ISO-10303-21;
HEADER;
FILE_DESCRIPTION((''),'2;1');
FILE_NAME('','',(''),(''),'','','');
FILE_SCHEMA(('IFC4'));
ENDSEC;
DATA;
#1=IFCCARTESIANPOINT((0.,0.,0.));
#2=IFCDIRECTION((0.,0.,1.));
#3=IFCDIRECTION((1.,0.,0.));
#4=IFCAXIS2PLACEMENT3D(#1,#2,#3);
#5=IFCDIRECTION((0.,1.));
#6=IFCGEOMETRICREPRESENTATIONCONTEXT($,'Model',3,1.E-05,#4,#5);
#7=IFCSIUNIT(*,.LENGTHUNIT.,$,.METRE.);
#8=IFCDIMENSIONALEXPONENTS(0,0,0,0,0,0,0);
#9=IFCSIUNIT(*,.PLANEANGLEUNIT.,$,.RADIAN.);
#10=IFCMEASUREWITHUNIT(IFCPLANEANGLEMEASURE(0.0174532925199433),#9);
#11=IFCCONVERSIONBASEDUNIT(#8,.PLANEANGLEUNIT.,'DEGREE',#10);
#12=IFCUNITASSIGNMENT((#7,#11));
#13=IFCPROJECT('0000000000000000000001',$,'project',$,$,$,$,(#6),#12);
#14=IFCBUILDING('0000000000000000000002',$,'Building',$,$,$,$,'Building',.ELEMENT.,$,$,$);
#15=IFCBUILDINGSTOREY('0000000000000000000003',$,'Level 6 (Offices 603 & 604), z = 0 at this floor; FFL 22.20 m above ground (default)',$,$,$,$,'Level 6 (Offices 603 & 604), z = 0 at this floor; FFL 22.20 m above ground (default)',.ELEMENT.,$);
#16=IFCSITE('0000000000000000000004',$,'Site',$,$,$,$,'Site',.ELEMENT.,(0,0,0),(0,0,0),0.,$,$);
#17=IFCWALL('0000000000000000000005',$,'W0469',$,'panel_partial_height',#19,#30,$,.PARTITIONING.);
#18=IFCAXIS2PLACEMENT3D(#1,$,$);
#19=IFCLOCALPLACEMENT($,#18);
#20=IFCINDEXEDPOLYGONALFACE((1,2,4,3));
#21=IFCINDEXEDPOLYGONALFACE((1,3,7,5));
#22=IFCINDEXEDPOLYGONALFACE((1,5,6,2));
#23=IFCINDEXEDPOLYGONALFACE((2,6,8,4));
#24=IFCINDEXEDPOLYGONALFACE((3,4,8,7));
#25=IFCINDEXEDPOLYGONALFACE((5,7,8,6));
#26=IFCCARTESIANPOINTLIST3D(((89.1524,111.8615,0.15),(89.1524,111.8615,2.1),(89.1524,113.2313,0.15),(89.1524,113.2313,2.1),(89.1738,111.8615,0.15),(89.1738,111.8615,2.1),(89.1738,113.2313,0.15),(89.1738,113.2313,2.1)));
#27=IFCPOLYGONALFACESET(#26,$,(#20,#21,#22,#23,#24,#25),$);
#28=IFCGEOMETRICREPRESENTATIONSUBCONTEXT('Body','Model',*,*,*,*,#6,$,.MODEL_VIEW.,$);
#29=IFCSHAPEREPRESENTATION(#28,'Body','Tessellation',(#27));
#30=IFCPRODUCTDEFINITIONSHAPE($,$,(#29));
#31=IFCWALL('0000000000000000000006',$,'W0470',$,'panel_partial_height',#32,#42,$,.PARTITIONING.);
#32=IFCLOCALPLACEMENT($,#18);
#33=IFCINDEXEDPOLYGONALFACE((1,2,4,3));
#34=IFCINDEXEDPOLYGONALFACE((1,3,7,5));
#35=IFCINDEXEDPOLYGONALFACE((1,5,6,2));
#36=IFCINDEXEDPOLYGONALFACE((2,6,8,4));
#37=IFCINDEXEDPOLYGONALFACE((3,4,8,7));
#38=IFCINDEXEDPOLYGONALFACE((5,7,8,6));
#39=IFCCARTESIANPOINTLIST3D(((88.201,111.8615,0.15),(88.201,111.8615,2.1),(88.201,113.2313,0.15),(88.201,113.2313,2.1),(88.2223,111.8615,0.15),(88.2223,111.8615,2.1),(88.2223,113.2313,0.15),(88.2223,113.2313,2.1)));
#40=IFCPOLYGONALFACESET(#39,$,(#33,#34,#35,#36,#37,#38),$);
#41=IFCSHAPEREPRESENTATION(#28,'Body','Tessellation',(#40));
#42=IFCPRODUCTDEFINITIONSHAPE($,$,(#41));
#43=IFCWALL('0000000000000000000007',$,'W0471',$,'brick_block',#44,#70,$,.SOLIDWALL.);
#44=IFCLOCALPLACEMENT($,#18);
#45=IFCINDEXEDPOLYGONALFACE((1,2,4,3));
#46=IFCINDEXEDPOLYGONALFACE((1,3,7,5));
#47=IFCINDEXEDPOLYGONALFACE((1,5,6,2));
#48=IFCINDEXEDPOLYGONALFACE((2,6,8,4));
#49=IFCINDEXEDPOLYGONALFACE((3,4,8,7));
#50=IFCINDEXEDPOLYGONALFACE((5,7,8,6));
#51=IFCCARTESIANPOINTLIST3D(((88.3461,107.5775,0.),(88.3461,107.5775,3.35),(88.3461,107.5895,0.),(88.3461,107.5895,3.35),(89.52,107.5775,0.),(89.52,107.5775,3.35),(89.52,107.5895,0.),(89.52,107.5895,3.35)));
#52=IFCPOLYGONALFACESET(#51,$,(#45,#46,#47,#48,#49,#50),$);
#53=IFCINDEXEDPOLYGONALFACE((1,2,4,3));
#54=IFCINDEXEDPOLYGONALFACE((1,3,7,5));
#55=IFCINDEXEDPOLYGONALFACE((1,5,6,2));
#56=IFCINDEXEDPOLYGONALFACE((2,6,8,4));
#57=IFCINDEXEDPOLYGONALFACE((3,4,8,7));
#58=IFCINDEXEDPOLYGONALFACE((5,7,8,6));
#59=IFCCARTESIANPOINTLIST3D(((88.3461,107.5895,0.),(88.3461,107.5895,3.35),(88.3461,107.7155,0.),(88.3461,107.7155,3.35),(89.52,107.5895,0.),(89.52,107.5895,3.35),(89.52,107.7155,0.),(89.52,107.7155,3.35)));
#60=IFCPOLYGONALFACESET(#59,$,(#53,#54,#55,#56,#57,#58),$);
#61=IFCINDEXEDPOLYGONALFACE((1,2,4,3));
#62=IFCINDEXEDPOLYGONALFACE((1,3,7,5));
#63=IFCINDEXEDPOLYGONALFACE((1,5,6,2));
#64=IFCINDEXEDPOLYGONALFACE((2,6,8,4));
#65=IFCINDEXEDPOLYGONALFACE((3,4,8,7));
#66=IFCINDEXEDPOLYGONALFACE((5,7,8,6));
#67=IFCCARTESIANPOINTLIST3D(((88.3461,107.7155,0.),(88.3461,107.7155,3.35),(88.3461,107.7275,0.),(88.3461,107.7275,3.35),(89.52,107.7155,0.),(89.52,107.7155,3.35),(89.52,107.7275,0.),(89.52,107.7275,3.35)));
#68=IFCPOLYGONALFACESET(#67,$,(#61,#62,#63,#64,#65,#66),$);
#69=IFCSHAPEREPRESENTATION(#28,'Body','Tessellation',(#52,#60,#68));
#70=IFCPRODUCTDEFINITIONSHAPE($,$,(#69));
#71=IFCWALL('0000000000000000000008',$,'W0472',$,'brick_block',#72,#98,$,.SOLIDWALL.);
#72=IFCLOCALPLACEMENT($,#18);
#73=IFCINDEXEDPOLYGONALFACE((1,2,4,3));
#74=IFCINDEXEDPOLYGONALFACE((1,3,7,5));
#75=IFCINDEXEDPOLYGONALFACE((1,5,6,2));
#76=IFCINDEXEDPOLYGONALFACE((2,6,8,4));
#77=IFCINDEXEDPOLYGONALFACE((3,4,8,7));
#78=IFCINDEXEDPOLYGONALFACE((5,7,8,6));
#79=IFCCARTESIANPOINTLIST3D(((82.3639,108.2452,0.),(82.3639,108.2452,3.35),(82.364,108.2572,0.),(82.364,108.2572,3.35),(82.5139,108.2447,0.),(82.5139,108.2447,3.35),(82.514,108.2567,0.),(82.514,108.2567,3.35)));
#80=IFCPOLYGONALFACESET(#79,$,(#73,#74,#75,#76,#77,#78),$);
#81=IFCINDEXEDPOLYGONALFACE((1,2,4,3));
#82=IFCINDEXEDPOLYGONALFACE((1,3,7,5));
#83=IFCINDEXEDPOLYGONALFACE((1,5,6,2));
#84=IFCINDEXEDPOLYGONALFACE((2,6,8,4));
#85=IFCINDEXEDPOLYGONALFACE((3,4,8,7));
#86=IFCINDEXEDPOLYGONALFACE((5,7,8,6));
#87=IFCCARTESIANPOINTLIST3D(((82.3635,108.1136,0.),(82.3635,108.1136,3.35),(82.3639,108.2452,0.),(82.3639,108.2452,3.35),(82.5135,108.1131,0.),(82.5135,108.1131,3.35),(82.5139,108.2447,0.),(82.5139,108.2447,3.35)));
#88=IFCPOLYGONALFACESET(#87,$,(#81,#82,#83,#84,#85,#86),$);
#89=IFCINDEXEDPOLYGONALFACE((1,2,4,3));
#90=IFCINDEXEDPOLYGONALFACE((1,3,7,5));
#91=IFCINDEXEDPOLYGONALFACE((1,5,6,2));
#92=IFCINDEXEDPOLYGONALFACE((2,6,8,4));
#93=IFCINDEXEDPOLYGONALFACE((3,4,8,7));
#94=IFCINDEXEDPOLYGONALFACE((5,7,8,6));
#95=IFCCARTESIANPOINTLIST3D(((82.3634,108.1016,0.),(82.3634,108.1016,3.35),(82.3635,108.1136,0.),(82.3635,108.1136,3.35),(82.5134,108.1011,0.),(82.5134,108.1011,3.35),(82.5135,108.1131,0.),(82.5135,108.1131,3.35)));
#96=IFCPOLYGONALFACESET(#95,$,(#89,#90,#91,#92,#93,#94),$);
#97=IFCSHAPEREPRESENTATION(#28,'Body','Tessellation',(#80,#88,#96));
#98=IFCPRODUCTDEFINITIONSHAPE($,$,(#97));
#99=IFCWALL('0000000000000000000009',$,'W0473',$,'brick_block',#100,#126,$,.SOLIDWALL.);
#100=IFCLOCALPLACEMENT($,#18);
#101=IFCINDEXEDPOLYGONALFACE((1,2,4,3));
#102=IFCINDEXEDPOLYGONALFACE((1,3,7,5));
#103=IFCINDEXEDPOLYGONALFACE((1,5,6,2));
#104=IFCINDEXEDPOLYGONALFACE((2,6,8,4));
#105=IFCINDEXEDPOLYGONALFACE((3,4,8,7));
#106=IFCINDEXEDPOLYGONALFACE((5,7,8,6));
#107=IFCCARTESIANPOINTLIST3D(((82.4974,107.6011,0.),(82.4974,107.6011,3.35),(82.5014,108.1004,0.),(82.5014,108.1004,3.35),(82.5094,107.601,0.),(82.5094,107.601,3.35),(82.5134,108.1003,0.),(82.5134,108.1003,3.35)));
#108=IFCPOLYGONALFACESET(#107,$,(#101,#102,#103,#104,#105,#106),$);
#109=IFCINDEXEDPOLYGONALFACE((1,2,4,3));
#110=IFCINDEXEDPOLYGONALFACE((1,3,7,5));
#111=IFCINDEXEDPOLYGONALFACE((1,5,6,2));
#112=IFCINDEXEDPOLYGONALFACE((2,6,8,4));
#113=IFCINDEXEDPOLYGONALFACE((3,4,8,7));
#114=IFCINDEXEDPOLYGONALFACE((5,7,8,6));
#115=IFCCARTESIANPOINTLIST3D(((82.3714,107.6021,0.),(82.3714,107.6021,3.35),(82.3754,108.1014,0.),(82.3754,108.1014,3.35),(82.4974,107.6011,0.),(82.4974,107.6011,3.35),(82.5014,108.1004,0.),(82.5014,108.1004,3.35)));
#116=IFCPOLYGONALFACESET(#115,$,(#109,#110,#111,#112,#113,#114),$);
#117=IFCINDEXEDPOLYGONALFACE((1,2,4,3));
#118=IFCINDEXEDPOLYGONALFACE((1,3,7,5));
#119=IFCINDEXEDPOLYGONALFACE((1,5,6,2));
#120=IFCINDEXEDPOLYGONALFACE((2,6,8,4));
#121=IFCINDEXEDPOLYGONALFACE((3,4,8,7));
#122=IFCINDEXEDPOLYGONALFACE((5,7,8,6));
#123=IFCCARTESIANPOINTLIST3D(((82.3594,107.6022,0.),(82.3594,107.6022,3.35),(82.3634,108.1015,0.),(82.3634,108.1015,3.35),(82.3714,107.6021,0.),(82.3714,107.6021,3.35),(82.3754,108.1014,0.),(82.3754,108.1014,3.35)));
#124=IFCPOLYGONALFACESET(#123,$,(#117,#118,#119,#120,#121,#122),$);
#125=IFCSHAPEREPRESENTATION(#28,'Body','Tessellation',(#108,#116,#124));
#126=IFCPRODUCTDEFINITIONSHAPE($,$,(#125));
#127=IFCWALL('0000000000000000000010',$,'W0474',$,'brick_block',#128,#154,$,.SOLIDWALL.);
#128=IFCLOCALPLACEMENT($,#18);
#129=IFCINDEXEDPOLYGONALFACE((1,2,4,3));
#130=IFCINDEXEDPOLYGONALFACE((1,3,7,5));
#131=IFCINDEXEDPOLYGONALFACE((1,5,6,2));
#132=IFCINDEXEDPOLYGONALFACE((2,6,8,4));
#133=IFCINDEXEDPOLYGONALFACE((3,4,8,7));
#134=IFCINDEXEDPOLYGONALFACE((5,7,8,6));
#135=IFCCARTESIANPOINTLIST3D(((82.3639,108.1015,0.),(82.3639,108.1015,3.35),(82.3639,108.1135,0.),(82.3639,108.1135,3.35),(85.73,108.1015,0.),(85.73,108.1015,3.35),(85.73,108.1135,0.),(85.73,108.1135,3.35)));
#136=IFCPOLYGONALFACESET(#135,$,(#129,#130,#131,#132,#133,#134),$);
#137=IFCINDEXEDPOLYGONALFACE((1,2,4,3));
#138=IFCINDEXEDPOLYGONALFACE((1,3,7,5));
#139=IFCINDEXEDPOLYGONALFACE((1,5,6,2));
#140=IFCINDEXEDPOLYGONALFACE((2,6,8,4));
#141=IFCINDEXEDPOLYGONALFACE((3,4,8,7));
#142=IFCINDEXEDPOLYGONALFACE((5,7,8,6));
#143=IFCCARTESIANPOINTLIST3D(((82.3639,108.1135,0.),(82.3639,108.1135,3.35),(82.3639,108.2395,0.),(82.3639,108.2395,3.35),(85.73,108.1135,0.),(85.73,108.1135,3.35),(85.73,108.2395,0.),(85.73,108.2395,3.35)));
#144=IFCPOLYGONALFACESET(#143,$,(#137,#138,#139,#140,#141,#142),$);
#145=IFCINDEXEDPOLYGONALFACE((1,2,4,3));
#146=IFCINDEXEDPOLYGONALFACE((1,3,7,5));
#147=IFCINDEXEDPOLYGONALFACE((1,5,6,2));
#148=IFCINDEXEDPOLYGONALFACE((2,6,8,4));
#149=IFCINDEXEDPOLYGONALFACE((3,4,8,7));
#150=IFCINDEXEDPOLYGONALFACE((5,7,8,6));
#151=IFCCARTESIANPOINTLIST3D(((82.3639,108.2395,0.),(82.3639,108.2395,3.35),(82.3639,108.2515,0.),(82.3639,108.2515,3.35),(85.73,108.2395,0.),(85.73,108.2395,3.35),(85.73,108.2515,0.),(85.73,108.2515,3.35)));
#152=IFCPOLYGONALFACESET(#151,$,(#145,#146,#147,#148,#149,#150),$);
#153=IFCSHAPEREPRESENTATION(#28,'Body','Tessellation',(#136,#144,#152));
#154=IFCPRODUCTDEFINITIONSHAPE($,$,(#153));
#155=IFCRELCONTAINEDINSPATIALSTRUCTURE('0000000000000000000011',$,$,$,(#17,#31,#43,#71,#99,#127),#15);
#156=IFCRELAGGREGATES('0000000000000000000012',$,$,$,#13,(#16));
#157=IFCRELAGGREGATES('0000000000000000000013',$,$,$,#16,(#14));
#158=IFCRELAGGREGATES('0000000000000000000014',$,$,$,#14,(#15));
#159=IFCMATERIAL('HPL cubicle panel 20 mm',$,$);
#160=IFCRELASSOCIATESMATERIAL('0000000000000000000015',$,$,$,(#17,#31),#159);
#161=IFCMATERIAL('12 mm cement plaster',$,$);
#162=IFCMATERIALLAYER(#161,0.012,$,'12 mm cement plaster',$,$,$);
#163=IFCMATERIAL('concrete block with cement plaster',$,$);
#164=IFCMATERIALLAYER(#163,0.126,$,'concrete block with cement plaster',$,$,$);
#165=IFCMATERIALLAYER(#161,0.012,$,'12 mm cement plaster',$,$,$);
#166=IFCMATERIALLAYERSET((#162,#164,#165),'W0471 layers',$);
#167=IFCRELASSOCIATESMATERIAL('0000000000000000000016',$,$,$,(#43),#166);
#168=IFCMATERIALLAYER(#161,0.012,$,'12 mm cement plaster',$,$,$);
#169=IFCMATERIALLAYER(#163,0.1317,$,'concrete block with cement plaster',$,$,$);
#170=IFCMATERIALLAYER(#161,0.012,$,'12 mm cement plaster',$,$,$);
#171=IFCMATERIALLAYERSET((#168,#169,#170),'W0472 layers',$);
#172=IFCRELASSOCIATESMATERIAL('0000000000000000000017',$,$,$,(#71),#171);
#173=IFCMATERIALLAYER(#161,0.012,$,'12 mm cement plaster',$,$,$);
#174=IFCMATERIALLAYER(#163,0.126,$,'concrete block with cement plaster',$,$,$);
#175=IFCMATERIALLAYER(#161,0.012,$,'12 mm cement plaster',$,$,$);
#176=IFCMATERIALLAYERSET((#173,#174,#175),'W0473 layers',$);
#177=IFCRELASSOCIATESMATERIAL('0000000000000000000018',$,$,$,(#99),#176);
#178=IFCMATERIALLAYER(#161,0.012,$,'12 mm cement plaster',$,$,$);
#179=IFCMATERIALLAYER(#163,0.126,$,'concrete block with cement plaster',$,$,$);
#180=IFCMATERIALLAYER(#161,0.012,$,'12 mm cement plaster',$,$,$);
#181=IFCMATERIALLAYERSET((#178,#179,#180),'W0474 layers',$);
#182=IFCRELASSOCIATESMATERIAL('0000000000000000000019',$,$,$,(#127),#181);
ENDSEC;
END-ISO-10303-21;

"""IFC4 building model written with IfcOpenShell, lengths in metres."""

from ifc_helpers import new_model, entity, si_unit, converted_unit, direction, frame, frame_2d, origin_with_axes, place, context, subcontext, project, spatial, rectangle, extrude, material, layer, layer_set, layer_usage, element, save


model = new_model("IFC4")

# Units and contexts
model_context = context("Model", 3, precision=1e-05, world=origin_with_axes(), true_north=direction((0.0, 1.0)))
body_context = subcontext(model_context, "Body", "Model", "MODEL_VIEW")
ifc_project = project(units=[si_unit("LENGTHUNIT", "METRE"), converted_unit("PLANEANGLEUNIT", "DEGREE", entity("IfcPlaneAngleMeasure", 0.0174532925199433), si_unit("PLANEANGLEUNIT", "RADIAN"), dimensions=[0, 0, 0, 0, 0, 0, 0])], contexts=[model_context])

# Site, building, storey
site = spatial("IfcSite", under=ifc_project, Name="Site", LongName="Site", CompositionType="ELEMENT", RefLatitude=(0, 0, 0), RefLongitude=(0, 0, 0), RefElevation=0.0)
building = spatial("IfcBuilding", under=site, Name="Building", LongName="Building", CompositionType="ELEMENT")
storey = spatial("IfcBuildingStorey", under=building, Name="Level 6 (Offices 603 & 604), z = 0 at this floor; FFL 22.20 m above ground (default)", LongName="Level 6 (Offices 603 & 604), z = 0 at this floor; FFL 22.20 m above ground (default)", CompositionType="ELEMENT")

# Walls
ifc_material_1 = material(Name="HPL cubicle panel 20 mm")
placement = place(None, origin_with_axes())
element("IfcWall", 1, at=placement, inside=storey, material=ifc_material_1, Name="W0469", ObjectType="panel_partial_height", PredefinedType="PARTITIONING", context=body_context, shape_type="SweptSolid", body=[
    extrude(rectangle(XDim=1.3698, YDim=0.0213, at=frame_2d((0.0, 0.0), x_axis=(0.0, 1.0))), frame((89.1631, 112.5464, 0.15), z_axis=(0.0, 0.0, 1.0), x_axis=(1.0, 0.0, 0.0)), (0.0, 0.0, 1.0), 1.95),
])
element("IfcWall", 2, at=placement, inside=storey, material=ifc_material_1, Name="W0470", ObjectType="panel_partial_height", PredefinedType="PARTITIONING", context=body_context, shape_type="SweptSolid", body=[
    extrude(rectangle(XDim=1.3698, YDim=0.0213, at=frame_2d((0.0, 0.0), x_axis=(0.0, 1.0))), frame((88.2117, 112.5464, 0.15), z_axis=(0.0, 0.0, 1.0), x_axis=(1.0, 0.0, 0.0)), (0.0, 0.0, 1.0), 1.95),
])
ifc_material_2 = material(Name="12 mm cement plaster")
ifc_layer_1 = layer(ifc_material_2, 0.012, Name="12 mm cement plaster")
ifc_material_3 = material(Name="concrete block with cement plaster")
ifc_layer_2 = layer(ifc_material_3, 0.126, Name="concrete block with cement plaster")
ifc_layer_3 = layer(ifc_material_2, 0.012, Name="12 mm cement plaster")
ifc_layer_set_1 = layer_set([ifc_layer_1, ifc_layer_2, ifc_layer_3], Name="W0471 layers")
ifc_layer_usage_1 = layer_usage(ifc_layer_set_1, "AXIS2", "POSITIVE", -0.075)
element("IfcWall", 3, at=placement, inside=storey, material=ifc_layer_usage_1, Name="W0471", ObjectType="brick_block", PredefinedType="SOLIDWALL", context=body_context, shape_type="SweptSolid", body=[
    extrude(rectangle(XDim=1.1739, YDim=0.012, at=frame_2d((0.0, 0.0), x_axis=(1.0, 0.0))), frame((88.933, 107.5835, 0.0), z_axis=(0.0, 0.0, 1.0), x_axis=(1.0, 0.0, 0.0)), (0.0, 0.0, 1.0), 3.35),
    extrude(rectangle(XDim=1.1739, YDim=0.126, at=frame_2d((0.0, 0.069), x_axis=(1.0, 0.0))), frame((88.933, 107.5835, 0.0), z_axis=(0.0, 0.0, 1.0), x_axis=(1.0, 0.0, 0.0)), (0.0, 0.0, 1.0), 3.35),
    extrude(rectangle(XDim=1.1739, YDim=0.012, at=frame_2d((0.0, 0.138), x_axis=(1.0, 0.0))), frame((88.933, 107.5835, 0.0), z_axis=(0.0, 0.0, 1.0), x_axis=(1.0, 0.0, 0.0)), (0.0, 0.0, 1.0), 3.35),
])
ifc_layer_4 = layer(ifc_material_2, 0.012, Name="12 mm cement plaster")
ifc_layer_5 = layer(ifc_material_3, 0.1317, Name="concrete block with cement plaster")
ifc_layer_6 = layer(ifc_material_2, 0.012, Name="12 mm cement plaster")
ifc_layer_set_2 = layer_set([ifc_layer_4, ifc_layer_5, ifc_layer_6], Name="W0472 layers")
ifc_layer_usage_2 = layer_usage(ifc_layer_set_2, "AXIS2", "POSITIVE", -0.0779)
element("IfcWall", 4, at=placement, inside=storey, material=ifc_layer_usage_2, Name="W0472", ObjectType="brick_block", PredefinedType="SOLIDWALL", context=body_context, shape_type="SweptSolid", body=[
    extrude(rectangle(XDim=0.15, YDim=0.012, at=frame_2d((0.0, 0.0), x_axis=(0.999994, -0.003333))), frame((82.4389, 108.251, 0.0), z_axis=(0.0, 0.0, 1.0), x_axis=(1.0, 0.0, 0.0)), (0.0, 0.0, 1.0), 3.35),
    extrude(rectangle(XDim=0.15, YDim=0.1317, at=frame_2d((-0.0002, -0.0718), x_axis=(0.999994, -0.003333))), frame((82.4389, 108.251, 0.0), z_axis=(0.0, 0.0, 1.0), x_axis=(1.0, 0.0, 0.0)), (0.0, 0.0, 1.0), 3.35),
    extrude(rectangle(XDim=0.15, YDim=0.012, at=frame_2d((-0.0005, -0.1437), x_axis=(0.999994, -0.003333))), frame((82.4389, 108.251, 0.0), z_axis=(0.0, 0.0, 1.0), x_axis=(1.0, 0.0, 0.0)), (0.0, 0.0, 1.0), 3.35),
])
ifc_layer_7 = layer(ifc_material_2, 0.012, Name="12 mm cement plaster")
ifc_layer_8 = layer(ifc_material_3, 0.126, Name="concrete block with cement plaster")
ifc_layer_9 = layer(ifc_material_2, 0.012, Name="12 mm cement plaster")
ifc_layer_set_3 = layer_set([ifc_layer_7, ifc_layer_8, ifc_layer_9], Name="W0473 layers")
ifc_layer_usage_3 = layer_usage(ifc_layer_set_3, "AXIS2", "POSITIVE", -0.075)
element("IfcWall", 5, at=placement, inside=storey, material=ifc_layer_usage_3, Name="W0473", ObjectType="brick_block", PredefinedType="SOLIDWALL", context=body_context, shape_type="SweptSolid", body=[
    extrude(rectangle(XDim=0.4993, YDim=0.012, at=frame_2d((0.0, 0.0), x_axis=(0.008011, 0.999968))), frame((82.5054, 107.8507, 0.0), z_axis=(0.0, 0.0, 1.0), x_axis=(1.0, 0.0, 0.0)), (0.0, 0.0, 1.0), 3.35),
    extrude(rectangle(XDim=0.4993, YDim=0.126, at=frame_2d((-0.069, 0.0006), x_axis=(0.008011, 0.999968))), frame((82.5054, 107.8507, 0.0), z_axis=(0.0, 0.0, 1.0), x_axis=(1.0, 0.0, 0.0)), (0.0, 0.0, 1.0), 3.35),
    extrude(rectangle(XDim=0.4993, YDim=0.012, at=frame_2d((-0.138, 0.0011), x_axis=(0.008011, 0.999968))), frame((82.5054, 107.8507, 0.0), z_axis=(0.0, 0.0, 1.0), x_axis=(1.0, 0.0, 0.0)), (0.0, 0.0, 1.0), 3.35),
])
ifc_layer_10 = layer(ifc_material_2, 0.012, Name="12 mm cement plaster")
ifc_layer_11 = layer(ifc_material_3, 0.126, Name="concrete block with cement plaster")
ifc_layer_12 = layer(ifc_material_2, 0.012, Name="12 mm cement plaster")
ifc_layer_set_4 = layer_set([ifc_layer_10, ifc_layer_11, ifc_layer_12], Name="W0474 layers")
ifc_layer_usage_4 = layer_usage(ifc_layer_set_4, "AXIS2", "POSITIVE", -0.075)
element("IfcWall", 6, at=placement, inside=storey, material=ifc_layer_usage_4, Name="W0474", ObjectType="brick_block", PredefinedType="SOLIDWALL", context=body_context, shape_type="SweptSolid", body=[
    extrude(rectangle(XDim=3.3661, YDim=0.012, at=frame_2d((0.0, 0.0), x_axis=(1.0, 0.0))), frame((84.0469, 108.1075, 0.0), z_axis=(0.0, 0.0, 1.0), x_axis=(1.0, 0.0, 0.0)), (0.0, 0.0, 1.0), 3.35),
    extrude(rectangle(XDim=3.3661, YDim=0.126, at=frame_2d((0.0, 0.069), x_axis=(1.0, 0.0))), frame((84.0469, 108.1075, 0.0), z_axis=(0.0, 0.0, 1.0), x_axis=(1.0, 0.0, 0.0)), (0.0, 0.0, 1.0), 3.35),
    extrude(rectangle(XDim=3.3661, YDim=0.012, at=frame_2d((0.0, 0.138), x_axis=(1.0, 0.0))), frame((84.0469, 108.1075, 0.0), z_axis=(0.0, 0.0, 1.0), x_axis=(1.0, 0.0, 0.0)), (0.0, 0.0, 1.0), 3.35),
])

save(model, "model.ifc")
